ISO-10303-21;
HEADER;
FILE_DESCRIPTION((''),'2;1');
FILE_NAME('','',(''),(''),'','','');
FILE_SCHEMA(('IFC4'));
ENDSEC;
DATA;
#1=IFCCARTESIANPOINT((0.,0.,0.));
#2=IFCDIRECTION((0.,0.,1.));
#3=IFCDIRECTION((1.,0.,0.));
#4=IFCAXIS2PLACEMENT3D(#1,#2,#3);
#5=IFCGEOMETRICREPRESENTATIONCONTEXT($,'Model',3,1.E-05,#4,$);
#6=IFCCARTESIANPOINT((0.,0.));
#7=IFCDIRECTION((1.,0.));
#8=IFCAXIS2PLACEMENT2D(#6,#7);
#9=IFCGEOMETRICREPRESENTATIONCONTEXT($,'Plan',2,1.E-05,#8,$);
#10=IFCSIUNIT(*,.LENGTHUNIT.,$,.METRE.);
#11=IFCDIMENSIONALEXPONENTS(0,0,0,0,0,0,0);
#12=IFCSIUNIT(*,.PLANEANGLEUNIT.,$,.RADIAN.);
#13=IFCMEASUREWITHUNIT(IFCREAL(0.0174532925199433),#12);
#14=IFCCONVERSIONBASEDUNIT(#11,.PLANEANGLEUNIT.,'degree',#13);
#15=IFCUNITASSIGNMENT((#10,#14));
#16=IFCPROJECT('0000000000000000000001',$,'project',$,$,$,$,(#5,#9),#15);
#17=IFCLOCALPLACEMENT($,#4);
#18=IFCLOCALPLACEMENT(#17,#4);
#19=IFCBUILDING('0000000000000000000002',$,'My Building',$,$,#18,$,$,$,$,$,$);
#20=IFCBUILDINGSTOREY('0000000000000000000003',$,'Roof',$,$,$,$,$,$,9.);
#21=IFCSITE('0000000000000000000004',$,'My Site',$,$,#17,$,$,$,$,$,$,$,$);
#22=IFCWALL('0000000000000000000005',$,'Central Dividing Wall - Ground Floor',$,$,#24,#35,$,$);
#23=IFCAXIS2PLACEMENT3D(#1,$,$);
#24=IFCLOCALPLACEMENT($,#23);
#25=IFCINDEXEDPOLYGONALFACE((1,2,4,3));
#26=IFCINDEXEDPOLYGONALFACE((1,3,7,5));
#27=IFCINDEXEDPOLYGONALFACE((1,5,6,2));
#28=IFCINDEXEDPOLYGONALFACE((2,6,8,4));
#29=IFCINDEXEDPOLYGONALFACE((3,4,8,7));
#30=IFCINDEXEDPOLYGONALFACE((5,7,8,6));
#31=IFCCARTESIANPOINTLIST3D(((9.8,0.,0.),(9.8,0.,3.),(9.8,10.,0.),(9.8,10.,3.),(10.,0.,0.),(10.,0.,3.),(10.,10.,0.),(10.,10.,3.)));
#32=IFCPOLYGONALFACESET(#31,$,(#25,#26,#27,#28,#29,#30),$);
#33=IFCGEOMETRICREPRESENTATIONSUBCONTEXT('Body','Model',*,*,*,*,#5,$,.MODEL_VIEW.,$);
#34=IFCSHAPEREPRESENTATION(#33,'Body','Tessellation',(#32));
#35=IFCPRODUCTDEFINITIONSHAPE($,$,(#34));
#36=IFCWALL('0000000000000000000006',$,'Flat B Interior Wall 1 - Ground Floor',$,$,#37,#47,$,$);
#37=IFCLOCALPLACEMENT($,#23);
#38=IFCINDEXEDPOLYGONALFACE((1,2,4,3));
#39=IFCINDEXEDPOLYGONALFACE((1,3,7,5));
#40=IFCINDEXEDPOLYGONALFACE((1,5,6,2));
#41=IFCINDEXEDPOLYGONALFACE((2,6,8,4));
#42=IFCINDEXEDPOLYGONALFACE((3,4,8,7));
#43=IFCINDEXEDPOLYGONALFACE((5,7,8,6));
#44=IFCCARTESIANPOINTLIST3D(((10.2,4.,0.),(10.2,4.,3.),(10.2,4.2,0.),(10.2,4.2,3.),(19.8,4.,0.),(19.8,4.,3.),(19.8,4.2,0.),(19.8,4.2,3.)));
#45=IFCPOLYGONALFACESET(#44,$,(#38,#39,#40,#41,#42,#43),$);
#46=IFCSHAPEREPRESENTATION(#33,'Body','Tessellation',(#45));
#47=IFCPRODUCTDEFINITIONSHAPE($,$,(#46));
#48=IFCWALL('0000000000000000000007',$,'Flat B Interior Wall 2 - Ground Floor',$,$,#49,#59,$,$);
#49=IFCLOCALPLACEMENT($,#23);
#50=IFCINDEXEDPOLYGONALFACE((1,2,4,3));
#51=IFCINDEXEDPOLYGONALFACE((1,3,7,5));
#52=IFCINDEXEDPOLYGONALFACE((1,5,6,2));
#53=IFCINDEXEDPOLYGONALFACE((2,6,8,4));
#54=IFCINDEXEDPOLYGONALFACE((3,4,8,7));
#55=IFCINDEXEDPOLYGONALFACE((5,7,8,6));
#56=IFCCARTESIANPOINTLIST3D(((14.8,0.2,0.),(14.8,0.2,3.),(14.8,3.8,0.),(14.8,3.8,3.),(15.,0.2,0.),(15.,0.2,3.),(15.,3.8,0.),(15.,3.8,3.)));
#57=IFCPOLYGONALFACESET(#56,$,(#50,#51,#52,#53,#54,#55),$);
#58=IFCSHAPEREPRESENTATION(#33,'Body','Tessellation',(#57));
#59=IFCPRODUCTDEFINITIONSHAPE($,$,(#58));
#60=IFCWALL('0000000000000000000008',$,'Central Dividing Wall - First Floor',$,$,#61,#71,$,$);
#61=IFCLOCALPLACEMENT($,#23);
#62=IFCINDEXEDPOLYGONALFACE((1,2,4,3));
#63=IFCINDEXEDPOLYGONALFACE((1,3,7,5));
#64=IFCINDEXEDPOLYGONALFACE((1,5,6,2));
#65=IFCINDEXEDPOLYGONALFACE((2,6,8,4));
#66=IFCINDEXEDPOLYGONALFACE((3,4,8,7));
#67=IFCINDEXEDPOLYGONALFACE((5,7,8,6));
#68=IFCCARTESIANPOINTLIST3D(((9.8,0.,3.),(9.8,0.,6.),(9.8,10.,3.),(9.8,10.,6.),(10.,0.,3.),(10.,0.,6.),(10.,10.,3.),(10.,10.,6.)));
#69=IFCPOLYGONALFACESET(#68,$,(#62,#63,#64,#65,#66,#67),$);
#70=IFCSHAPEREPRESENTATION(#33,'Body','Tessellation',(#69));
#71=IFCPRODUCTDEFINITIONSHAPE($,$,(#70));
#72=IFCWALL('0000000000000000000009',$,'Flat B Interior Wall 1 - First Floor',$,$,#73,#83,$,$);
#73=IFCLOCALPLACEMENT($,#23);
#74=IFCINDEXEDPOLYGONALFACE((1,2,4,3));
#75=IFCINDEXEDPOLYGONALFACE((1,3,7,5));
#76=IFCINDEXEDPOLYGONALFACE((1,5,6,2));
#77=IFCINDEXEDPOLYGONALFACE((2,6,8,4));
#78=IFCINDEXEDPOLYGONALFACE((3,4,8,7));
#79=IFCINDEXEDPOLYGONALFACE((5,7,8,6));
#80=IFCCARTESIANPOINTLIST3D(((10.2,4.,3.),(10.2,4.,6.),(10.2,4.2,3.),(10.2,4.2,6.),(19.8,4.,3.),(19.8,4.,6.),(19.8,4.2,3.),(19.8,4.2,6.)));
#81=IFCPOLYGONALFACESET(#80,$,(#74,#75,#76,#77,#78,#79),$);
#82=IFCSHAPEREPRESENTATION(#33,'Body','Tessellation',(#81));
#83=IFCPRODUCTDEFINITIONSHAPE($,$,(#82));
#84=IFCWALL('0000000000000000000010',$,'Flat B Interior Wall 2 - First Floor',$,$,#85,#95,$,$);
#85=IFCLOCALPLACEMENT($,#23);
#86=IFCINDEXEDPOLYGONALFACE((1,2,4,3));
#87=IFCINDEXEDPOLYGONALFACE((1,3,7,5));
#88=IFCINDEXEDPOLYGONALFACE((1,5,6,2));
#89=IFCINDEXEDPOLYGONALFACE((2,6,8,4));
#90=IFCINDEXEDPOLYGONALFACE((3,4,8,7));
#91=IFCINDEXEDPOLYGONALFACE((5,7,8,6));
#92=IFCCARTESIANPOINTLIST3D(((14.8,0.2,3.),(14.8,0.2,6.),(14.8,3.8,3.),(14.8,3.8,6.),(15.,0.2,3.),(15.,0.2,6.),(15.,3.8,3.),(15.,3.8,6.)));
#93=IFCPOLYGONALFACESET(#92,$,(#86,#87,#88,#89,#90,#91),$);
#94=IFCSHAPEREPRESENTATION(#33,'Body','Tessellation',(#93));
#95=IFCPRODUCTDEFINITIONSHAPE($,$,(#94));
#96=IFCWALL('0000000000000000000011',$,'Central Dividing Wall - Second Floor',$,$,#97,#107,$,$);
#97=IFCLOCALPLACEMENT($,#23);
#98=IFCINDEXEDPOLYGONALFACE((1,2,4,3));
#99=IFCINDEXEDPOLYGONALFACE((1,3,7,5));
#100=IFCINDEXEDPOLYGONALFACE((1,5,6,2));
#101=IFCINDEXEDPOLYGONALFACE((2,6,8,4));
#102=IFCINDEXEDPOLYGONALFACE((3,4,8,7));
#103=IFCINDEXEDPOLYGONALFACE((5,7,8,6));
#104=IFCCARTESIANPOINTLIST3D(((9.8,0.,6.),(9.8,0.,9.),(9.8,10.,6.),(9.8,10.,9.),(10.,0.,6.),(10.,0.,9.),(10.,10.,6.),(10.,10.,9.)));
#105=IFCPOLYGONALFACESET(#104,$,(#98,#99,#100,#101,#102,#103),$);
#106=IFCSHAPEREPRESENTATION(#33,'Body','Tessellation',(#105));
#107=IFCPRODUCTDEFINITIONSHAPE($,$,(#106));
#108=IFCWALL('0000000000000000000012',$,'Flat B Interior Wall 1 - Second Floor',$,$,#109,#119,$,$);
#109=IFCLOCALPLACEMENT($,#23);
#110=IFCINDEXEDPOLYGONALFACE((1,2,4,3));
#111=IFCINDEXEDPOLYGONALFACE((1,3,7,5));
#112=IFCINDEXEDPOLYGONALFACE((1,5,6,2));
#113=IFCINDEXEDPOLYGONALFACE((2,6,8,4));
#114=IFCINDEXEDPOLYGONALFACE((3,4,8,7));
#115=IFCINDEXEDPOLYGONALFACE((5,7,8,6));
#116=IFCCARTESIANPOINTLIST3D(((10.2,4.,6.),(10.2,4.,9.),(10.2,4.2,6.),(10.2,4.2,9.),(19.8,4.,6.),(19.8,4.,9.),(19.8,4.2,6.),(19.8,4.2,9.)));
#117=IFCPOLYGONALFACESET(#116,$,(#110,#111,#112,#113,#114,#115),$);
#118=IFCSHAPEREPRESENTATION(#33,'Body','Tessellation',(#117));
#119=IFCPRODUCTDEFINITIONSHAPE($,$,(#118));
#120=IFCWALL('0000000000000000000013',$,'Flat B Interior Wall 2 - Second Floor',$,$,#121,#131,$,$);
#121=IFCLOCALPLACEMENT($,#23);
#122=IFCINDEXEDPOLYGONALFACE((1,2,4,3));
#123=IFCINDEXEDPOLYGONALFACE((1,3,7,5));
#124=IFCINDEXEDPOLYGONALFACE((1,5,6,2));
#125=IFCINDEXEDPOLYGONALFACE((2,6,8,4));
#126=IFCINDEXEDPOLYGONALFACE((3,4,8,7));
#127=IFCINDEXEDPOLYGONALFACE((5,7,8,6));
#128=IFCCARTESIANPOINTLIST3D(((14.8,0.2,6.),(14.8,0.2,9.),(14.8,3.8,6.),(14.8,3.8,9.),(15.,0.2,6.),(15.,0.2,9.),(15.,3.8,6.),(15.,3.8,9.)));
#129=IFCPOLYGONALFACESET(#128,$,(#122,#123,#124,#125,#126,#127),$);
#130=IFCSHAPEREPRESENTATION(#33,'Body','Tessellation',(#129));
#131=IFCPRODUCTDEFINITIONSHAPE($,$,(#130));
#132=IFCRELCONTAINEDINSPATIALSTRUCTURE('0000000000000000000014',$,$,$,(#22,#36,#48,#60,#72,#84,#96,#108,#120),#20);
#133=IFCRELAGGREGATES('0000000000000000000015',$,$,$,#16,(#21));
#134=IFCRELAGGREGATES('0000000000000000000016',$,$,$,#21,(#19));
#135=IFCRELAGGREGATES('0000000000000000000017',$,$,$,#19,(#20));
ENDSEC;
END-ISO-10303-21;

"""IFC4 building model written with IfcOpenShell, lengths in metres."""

from ifc_helpers import new_model, entity, si_unit, converted_unit, frame, origin_with_axes, origin_2d_with_axis, place, context, subcontext, project, spatial, indexed_curve, outline, extrude, element, save


model = new_model("IFC4")

# Units and contexts
model_context = context("Model", 3, precision=1e-05, world=origin_with_axes())
plan_context = context("Plan", 2, precision=1e-05, world=origin_2d_with_axis())
body_context = subcontext(model_context, "Body", "Model", "MODEL_VIEW")
ifc_project = project(units=[si_unit("LENGTHUNIT", "METRE"), converted_unit("PLANEANGLEUNIT", "degree", entity("IfcReal", 0.0174532925199433), si_unit("PLANEANGLEUNIT", "RADIAN"), dimensions=[0, 0, 0, 0, 0, 0, 0])], contexts=[model_context, plan_context])

# Site, building, storey
site_placement = place(None, origin_with_axes())
site = spatial("IfcSite", under=ifc_project, at=site_placement, Name="My Site")
building_placement = place(site_placement, origin_with_axes())
building = spatial("IfcBuilding", under=site, at=building_placement, Name="My Building")
storey = spatial("IfcBuildingStorey", under=building, Name="Roof", Elevation=9.0)

# Walls
wall_1_placement = place(None, frame((10.0, 0.0, 0.0), z_axis=(0.0, 0.0, 1.0), x_axis=(0.0, 1.0, 0.0)))
element("IfcWall", 1, at=wall_1_placement, inside=storey, Name="Central Dividing Wall - Ground Floor", context=body_context, shape_type="SweptSolid", body=[
    extrude(outline(indexed_curve([(0.0, 0.0), (0.0, 0.2), (10.0, 0.2), (10.0, 0.0), (0.0, 0.0)], self_intersect=False)), origin_with_axes(), (0.0, 0.0, 1.0), 3.0),
])
wall_2_placement = place(None, frame((10.2, 4.0, 0.0), z_axis=(0.0, 0.0, 1.0), x_axis=(1.0, 0.0, 0.0)))
element("IfcWall", 2, at=wall_2_placement, inside=storey, Name="Flat B Interior Wall 1 - Ground Floor", context=body_context, shape_type="SweptSolid", body=[
    extrude(outline(indexed_curve([(0.0, 0.0), (0.0, 0.2), (9.6, 0.2), (9.6, 0.0), (0.0, 0.0)], self_intersect=False)), origin_with_axes(), (0.0, 0.0, 1.0), 3.0),
])
wall_3_placement = place(None, frame((15.0, 0.2, 0.0), z_axis=(0.0, 0.0, 1.0), x_axis=(0.0, 1.0, 0.0)))
element("IfcWall", 3, at=wall_3_placement, inside=storey, Name="Flat B Interior Wall 2 - Ground Floor", context=body_context, shape_type="SweptSolid", body=[
    extrude(outline(indexed_curve([(0.0, 0.0), (0.0, 0.2), (3.6, 0.2), (3.6, 0.0), (0.0, 0.0)], self_intersect=False)), origin_with_axes(), (0.0, 0.0, 1.0), 3.0),
])
wall_4_placement = place(None, frame((10.0, 0.0, 3.0), z_axis=(0.0, 0.0, 1.0), x_axis=(0.0, 1.0, 0.0)))
element("IfcWall", 4, at=wall_4_placement, inside=storey, Name="Central Dividing Wall - First Floor", context=body_context, shape_type="SweptSolid", body=[
    extrude(outline(indexed_curve([(0.0, 0.0), (0.0, 0.2), (10.0, 0.2), (10.0, 0.0), (0.0, 0.0)], self_intersect=False)), origin_with_axes(), (0.0, 0.0, 1.0), 3.0),
])
wall_5_placement = place(None, frame((10.2, 4.0, 3.0), z_axis=(0.0, 0.0, 1.0), x_axis=(1.0, 0.0, 0.0)))
element("IfcWall", 5, at=wall_5_placement, inside=storey, Name="Flat B Interior Wall 1 - First Floor", context=body_context, shape_type="SweptSolid", body=[
    extrude(outline(indexed_curve([(0.0, 0.0), (0.0, 0.2), (9.6, 0.2), (9.6, 0.0), (0.0, 0.0)], self_intersect=False)), origin_with_axes(), (0.0, 0.0, 1.0), 3.0),
])
wall_6_placement = place(None, frame((15.0, 0.2, 3.0), z_axis=(0.0, 0.0, 1.0), x_axis=(0.0, 1.0, 0.0)))
element("IfcWall", 6, at=wall_6_placement, inside=storey, Name="Flat B Interior Wall 2 - First Floor", context=body_context, shape_type="SweptSolid", body=[
    extrude(outline(indexed_curve([(0.0, 0.0), (0.0, 0.2), (3.6, 0.2), (3.6, 0.0), (0.0, 0.0)], self_intersect=False)), origin_with_axes(), (0.0, 0.0, 1.0), 3.0),
])
wall_7_placement = place(None, frame((10.0, 0.0, 6.0), z_axis=(0.0, 0.0, 1.0), x_axis=(0.0, 1.0, 0.0)))
element("IfcWall", 7, at=wall_7_placement, inside=storey, Name="Central Dividing Wall - Second Floor", context=body_context, shape_type="SweptSolid", body=[
    extrude(outline(indexed_curve([(0.0, 0.0), (0.0, 0.2), (10.0, 0.2), (10.0, 0.0), (0.0, 0.0)], self_intersect=False)), origin_with_axes(), (0.0, 0.0, 1.0), 3.0),
])
wall_8_placement = place(None, frame((10.2, 4.0, 6.0), z_axis=(0.0, 0.0, 1.0), x_axis=(1.0, 0.0, 0.0)))
element("IfcWall", 8, at=wall_8_placement, inside=storey, Name="Flat B Interior Wall 1 - Second Floor", context=body_context, shape_type="SweptSolid", body=[
    extrude(outline(indexed_curve([(0.0, 0.0), (0.0, 0.2), (9.6, 0.2), (9.6, 0.0), (0.0, 0.0)], self_intersect=False)), origin_with_axes(), (0.0, 0.0, 1.0), 3.0),
])
wall_9_placement = place(None, frame((15.0, 0.2, 6.0), z_axis=(0.0, 0.0, 1.0), x_axis=(0.0, 1.0, 0.0)))
element("IfcWall", 9, at=wall_9_placement, inside=storey, Name="Flat B Interior Wall 2 - Second Floor", context=body_context, shape_type="SweptSolid", body=[
    extrude(outline(indexed_curve([(0.0, 0.0), (0.0, 0.2), (3.6, 0.2), (3.6, 0.0), (0.0, 0.0)], self_intersect=False)), origin_with_axes(), (0.0, 0.0, 1.0), 3.0),
])

save(model, "model.ifc")
